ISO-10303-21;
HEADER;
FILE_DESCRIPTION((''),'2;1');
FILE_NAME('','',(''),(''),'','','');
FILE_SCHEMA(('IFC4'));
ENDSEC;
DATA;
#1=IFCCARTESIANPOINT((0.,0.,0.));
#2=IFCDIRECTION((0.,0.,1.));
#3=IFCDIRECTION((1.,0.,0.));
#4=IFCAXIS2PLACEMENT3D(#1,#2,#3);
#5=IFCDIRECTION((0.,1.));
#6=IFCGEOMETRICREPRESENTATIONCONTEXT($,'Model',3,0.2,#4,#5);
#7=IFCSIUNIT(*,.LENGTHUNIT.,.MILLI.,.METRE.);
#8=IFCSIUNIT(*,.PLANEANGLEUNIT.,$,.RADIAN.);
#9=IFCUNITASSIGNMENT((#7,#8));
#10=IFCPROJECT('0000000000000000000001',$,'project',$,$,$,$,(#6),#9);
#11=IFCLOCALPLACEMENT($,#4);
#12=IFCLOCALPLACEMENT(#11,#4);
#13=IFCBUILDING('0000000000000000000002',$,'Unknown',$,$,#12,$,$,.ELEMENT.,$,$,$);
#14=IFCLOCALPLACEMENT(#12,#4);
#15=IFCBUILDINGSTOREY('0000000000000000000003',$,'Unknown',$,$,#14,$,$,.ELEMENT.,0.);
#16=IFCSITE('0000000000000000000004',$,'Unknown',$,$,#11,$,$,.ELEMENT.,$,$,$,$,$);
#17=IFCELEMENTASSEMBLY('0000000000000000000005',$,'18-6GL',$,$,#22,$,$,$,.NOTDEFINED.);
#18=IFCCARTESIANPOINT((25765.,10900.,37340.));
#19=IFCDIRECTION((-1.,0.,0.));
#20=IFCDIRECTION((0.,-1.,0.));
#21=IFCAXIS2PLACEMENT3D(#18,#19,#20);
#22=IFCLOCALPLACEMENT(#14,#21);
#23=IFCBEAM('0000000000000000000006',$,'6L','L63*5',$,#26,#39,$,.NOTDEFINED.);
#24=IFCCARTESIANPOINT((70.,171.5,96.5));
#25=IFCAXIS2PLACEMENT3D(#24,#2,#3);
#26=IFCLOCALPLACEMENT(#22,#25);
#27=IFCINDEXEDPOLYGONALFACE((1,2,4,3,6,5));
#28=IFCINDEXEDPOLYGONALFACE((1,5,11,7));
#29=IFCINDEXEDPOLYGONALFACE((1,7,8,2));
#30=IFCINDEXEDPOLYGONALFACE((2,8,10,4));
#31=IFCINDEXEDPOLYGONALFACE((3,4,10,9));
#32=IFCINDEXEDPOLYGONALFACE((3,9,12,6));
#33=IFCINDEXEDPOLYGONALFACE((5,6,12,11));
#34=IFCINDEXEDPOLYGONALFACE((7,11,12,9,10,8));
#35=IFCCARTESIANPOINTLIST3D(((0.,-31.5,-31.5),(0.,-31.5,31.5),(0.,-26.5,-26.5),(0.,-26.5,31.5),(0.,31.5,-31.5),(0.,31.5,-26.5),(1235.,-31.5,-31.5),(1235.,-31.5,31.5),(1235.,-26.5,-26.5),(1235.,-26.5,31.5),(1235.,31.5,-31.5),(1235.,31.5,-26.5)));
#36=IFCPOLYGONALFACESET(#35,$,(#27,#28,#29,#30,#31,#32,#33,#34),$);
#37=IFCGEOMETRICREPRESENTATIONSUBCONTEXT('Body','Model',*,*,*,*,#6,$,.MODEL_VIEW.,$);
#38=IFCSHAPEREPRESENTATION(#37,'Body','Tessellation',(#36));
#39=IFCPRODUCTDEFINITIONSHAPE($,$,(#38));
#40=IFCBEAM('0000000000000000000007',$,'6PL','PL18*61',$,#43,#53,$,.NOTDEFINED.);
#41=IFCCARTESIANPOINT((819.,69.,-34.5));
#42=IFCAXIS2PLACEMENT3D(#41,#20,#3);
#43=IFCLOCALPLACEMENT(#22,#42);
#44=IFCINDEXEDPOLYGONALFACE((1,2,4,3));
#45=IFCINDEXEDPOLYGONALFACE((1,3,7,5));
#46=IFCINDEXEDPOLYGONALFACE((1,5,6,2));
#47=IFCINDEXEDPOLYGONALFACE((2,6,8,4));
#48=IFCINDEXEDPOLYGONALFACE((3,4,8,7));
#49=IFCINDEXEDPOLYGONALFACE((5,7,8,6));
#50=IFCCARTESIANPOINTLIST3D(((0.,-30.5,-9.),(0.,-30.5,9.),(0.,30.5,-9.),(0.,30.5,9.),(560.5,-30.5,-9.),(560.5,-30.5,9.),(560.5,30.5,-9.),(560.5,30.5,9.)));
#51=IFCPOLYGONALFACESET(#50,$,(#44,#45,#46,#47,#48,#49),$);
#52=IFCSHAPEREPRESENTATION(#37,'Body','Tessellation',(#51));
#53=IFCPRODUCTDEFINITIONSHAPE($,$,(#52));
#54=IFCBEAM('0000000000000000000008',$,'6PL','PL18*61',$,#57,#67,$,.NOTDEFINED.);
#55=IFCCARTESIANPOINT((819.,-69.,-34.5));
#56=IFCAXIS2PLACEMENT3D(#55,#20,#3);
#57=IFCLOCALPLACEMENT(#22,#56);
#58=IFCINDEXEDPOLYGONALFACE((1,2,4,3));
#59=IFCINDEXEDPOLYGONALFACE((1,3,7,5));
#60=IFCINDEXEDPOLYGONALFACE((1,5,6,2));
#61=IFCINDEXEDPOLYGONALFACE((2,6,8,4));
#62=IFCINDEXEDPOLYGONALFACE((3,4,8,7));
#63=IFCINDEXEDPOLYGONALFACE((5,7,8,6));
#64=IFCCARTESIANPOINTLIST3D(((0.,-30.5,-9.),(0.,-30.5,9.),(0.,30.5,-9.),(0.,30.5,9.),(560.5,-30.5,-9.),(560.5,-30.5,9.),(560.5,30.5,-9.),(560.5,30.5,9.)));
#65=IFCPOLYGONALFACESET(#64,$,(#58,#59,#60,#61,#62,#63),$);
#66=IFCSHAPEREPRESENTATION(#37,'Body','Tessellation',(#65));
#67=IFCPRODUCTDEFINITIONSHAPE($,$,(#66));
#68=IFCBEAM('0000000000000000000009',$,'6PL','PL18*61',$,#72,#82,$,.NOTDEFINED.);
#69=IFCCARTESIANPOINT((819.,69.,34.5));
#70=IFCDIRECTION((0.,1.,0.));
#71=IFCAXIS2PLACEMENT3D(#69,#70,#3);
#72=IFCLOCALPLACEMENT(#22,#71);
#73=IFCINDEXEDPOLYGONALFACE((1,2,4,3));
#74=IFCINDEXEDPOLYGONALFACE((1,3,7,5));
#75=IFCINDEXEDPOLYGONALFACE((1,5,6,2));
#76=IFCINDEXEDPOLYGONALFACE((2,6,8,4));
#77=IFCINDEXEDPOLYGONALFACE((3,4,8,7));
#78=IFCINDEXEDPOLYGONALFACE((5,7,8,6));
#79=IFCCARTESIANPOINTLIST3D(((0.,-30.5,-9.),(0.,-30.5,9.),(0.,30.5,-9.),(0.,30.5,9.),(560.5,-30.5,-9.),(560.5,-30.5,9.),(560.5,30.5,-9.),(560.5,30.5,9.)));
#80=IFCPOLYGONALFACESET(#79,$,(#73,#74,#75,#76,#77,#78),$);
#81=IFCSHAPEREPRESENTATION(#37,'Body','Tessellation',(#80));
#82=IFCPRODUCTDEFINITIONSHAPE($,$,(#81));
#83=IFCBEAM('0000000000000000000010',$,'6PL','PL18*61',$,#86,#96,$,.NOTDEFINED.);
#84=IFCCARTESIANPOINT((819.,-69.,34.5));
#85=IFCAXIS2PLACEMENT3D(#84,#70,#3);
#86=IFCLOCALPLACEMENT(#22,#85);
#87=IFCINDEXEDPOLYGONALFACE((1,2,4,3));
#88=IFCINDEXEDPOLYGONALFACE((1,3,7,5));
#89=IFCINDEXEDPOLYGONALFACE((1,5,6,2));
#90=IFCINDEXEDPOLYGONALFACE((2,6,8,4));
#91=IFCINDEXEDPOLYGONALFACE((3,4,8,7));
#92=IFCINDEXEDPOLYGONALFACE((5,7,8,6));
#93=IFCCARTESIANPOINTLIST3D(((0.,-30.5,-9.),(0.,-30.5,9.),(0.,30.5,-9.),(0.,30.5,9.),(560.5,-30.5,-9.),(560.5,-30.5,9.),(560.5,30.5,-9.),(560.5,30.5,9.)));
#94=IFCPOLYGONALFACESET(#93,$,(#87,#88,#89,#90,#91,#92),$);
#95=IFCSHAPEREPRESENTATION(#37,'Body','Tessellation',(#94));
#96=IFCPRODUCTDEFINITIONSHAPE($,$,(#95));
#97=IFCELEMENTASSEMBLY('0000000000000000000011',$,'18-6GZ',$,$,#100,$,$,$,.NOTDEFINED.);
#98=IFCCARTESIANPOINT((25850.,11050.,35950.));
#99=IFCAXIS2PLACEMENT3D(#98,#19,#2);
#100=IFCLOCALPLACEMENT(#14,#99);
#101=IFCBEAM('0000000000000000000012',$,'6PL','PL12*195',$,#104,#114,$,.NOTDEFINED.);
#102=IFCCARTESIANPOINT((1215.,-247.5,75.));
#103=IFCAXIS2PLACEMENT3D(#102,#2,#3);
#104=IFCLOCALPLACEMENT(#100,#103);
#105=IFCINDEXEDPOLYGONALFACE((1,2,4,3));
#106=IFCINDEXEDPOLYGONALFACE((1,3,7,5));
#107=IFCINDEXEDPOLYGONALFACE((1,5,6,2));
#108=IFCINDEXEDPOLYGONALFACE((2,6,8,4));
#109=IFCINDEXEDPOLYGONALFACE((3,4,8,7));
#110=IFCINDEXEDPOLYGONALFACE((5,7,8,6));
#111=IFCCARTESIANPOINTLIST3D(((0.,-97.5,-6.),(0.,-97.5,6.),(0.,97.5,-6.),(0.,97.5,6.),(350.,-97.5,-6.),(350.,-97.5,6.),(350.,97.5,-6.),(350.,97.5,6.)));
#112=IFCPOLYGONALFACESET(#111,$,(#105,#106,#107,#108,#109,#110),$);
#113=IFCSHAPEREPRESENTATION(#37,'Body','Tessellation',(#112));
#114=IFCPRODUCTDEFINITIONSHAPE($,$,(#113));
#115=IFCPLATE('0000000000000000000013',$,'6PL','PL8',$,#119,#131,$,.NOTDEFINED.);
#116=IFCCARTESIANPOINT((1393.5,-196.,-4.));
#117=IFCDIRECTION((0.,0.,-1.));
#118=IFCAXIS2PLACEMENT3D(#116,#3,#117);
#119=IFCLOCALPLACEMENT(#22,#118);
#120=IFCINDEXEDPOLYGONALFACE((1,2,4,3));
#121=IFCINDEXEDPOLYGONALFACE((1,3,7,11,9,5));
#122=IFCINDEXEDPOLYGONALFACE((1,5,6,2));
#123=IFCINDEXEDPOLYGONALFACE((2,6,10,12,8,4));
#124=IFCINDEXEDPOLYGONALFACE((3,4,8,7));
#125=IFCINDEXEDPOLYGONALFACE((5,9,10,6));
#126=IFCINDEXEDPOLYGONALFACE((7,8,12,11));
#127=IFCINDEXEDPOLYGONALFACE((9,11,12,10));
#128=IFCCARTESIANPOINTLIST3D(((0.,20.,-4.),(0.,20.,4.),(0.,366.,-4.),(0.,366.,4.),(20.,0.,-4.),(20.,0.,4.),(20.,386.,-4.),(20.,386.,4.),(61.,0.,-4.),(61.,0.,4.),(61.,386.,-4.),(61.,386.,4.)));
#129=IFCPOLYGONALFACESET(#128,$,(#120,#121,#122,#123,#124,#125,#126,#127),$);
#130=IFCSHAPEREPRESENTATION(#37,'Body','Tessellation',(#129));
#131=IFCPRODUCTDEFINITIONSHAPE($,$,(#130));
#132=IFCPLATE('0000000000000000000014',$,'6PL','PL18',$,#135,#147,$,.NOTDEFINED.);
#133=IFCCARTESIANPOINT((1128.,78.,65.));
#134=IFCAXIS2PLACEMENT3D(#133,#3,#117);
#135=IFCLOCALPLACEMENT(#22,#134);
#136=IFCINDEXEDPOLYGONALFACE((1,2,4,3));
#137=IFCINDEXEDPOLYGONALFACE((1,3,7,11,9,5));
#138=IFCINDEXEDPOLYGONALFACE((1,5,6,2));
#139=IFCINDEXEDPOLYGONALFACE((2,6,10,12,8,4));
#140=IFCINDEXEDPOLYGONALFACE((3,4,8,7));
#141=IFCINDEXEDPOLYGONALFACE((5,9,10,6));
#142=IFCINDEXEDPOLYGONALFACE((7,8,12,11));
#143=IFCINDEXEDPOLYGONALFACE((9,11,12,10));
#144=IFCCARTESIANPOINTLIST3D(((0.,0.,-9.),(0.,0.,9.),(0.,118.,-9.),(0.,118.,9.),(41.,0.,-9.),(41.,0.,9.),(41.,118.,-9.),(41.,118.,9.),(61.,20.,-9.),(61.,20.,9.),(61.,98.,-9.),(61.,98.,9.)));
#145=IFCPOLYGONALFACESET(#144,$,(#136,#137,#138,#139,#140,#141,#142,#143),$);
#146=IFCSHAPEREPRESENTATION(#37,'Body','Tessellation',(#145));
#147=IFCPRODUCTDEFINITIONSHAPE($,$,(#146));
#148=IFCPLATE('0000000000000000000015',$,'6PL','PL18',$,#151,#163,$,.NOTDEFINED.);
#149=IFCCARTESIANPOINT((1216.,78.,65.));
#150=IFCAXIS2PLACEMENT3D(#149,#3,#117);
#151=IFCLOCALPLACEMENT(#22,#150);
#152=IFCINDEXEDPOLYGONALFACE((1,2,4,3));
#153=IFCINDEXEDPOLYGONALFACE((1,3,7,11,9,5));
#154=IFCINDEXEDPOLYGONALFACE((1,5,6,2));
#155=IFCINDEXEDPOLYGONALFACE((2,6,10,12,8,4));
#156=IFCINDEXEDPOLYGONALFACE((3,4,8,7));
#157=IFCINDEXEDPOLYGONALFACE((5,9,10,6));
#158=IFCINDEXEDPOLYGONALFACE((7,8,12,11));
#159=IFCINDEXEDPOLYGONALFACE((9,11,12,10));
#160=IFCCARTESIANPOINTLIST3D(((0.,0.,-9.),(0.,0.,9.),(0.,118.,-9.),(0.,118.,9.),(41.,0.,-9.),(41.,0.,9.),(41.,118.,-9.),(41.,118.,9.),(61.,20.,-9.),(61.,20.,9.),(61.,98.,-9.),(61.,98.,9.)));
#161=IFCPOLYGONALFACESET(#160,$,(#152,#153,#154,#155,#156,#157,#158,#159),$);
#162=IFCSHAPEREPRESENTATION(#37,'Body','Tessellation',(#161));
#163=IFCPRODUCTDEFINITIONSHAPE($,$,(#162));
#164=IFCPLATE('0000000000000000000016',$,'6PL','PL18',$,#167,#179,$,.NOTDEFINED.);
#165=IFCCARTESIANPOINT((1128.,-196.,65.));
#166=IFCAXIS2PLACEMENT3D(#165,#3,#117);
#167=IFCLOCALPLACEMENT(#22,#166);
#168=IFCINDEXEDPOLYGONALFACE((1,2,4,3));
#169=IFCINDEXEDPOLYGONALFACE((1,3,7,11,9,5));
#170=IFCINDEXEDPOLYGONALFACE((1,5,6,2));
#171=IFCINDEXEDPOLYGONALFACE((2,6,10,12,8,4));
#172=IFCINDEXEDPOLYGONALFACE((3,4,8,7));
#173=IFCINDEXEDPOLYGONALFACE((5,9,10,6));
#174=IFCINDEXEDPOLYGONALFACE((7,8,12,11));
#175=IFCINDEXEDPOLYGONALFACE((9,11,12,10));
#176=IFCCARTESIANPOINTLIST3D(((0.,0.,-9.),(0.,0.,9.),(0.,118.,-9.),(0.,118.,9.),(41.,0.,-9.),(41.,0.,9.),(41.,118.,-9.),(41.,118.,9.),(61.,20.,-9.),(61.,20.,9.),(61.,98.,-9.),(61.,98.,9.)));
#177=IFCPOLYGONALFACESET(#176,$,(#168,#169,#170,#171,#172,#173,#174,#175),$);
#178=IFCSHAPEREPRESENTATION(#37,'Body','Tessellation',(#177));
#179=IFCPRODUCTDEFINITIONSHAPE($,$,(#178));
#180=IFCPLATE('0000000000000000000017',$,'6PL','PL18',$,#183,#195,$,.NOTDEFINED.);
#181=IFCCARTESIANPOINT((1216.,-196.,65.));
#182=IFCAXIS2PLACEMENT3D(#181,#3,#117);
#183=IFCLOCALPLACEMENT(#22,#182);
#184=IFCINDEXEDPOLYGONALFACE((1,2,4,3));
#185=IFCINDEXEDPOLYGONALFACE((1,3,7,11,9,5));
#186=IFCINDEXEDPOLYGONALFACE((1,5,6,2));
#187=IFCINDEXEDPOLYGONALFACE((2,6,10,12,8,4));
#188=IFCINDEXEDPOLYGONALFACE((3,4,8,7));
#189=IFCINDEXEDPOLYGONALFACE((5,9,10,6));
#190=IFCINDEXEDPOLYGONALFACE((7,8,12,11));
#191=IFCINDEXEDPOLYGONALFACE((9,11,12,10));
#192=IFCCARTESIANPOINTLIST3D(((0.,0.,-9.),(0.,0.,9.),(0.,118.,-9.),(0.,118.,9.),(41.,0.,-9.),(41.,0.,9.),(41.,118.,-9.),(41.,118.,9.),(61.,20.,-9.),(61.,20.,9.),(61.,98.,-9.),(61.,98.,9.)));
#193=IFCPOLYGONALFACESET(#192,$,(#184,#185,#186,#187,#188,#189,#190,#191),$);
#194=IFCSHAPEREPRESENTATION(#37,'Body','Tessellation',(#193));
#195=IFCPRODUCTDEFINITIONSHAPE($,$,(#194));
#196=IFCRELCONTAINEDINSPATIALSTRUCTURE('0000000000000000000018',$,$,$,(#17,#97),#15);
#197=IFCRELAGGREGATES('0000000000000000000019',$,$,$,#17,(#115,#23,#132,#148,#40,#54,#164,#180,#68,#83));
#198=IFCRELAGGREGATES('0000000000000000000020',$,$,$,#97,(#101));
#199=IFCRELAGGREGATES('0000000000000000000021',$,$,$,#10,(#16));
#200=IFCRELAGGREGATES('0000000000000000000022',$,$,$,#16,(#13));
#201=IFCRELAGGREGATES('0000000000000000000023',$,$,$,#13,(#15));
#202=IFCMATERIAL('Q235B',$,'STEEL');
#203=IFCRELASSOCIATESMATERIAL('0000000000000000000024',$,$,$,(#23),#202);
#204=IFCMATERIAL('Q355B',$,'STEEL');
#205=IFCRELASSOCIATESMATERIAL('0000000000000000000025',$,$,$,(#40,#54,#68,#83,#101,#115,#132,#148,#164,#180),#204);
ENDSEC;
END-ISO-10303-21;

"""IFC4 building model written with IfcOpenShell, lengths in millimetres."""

from ifc_helpers import new_model, si_unit, direction, frame, origin_with_axes, place, context, subcontext, project, spatial, line, indexed_curve, outline, extrude, material, element, aggregate, save


model = new_model("IFC4")

# Units and contexts
model_context = context("Model", 3, precision=0.2, world=origin_with_axes(), true_north=direction((0.0, 1.0)))
body_context = subcontext(model_context, "Body", "Model", "MODEL_VIEW")
ifc_project = project(units=[si_unit("LENGTHUNIT", "METRE", prefix="MILLI"), si_unit("PLANEANGLEUNIT", "RADIAN")], contexts=[model_context])

# Site, building, storey
site_placement = place(None, origin_with_axes())
site = spatial("IfcSite", under=ifc_project, at=site_placement, Name="Unknown", CompositionType="ELEMENT")
building_placement = place(site_placement, origin_with_axes())
building = spatial("IfcBuilding", under=site, at=building_placement, Name="Unknown", CompositionType="ELEMENT")
storey_placement = place(building_placement, origin_with_axes())
storey = spatial("IfcBuildingStorey", under=building, at=storey_placement, Name="Unknown", CompositionType="ELEMENT", Elevation=0.0)

# Element assembly, beams
assembly_1_placement = place(storey_placement, frame((25765.0, 10900.0, 37340.0), z_axis=(-1.0, 0.0, 0.0), x_axis=(0.0, -1.0, 0.0)))
assembly_1 = element("IfcElementAssembly", 1, at=assembly_1_placement, inside=storey, Name="18-6GL", PredefinedType="NOTDEFINED")
ifc_material_1 = material(Name="Q235B", Category="STEEL")
beam_1_placement = place(assembly_1_placement, frame((70.0, 171.5, 96.5), z_axis=(0.0, 0.0, 1.0), x_axis=(1.0, 0.0, 0.0)))
beam_1 = element("IfcBeam", 2, at=beam_1_placement, material=ifc_material_1, Name="6L", Description="L63*5", PredefinedType="NOTDEFINED", context=body_context, shape_type="SolidModel", body=[
    extrude(outline(indexed_curve([(-31.5, -31.5), (31.5, -31.5), (31.5, -26.5), (-26.5, -26.5), (-26.5, 31.5), (-31.5, 31.5)], segments=[line(1, 2, 3, 4, 5, 6, 1)])), frame((0.0, 0.0, 0.0), z_axis=(-1.0, 0.0, 0.0), x_axis=(0.0, 0.0, 1.0)), (0.0, 0.0, -1.0), 1235.0),
])
ifc_material_2 = material(Name="Q355B", Category="STEEL")
beam_2_placement = place(assembly_1_placement, frame((819.0, 69.0, -34.5), z_axis=(0.0, -1.0, 0.0), x_axis=(1.0, 0.0, 0.0)))
beam_2 = element("IfcBeam", 3, at=beam_2_placement, material=ifc_material_2, Name="6PL", Description="PL18*61", PredefinedType="NOTDEFINED", context=body_context, shape_type="SolidModel", body=[
    extrude(outline(indexed_curve([(-9.0, -30.5), (9.0, -30.5), (9.0, 30.5), (-9.0, 30.5)], segments=[line(1, 2, 3, 4, 1)])), frame((0.0, 0.0, 0.0), z_axis=(-1.0, 0.0, 0.0), x_axis=(0.0, 0.0, 1.0)), (0.0, 0.0, -1.0), 560.5),
])
beam_3_placement = place(assembly_1_placement, frame((819.0, -69.0, -34.5), z_axis=(0.0, -1.0, 0.0), x_axis=(1.0, 0.0, 0.0)))
beam_3 = element("IfcBeam", 4, at=beam_3_placement, material=ifc_material_2, Name="6PL", Description="PL18*61", PredefinedType="NOTDEFINED", context=body_context, shape_type="SolidModel", body=[
    extrude(outline(indexed_curve([(-9.0, -30.5), (9.0, -30.5), (9.0, 30.5), (-9.0, 30.5)], segments=[line(1, 2, 3, 4, 1)])), frame((0.0, 0.0, 0.0), z_axis=(-1.0, 0.0, 0.0), x_axis=(0.0, 0.0, 1.0)), (0.0, 0.0, -1.0), 560.5),
])
beam_4_placement = place(assembly_1_placement, frame((819.0, 69.0, 34.5), z_axis=(0.0, 1.0, 0.0), x_axis=(1.0, 0.0, 0.0)))
beam_4 = element("IfcBeam", 5, at=beam_4_placement, material=ifc_material_2, Name="6PL", Description="PL18*61", PredefinedType="NOTDEFINED", context=body_context, shape_type="SolidModel", body=[
    extrude(outline(indexed_curve([(-9.0, -30.5), (9.0, -30.5), (9.0, 30.5), (-9.0, 30.5)], segments=[line(1, 2, 3, 4, 1)])), frame((0.0, 0.0, 0.0), z_axis=(-1.0, 0.0, 0.0), x_axis=(0.0, 0.0, 1.0)), (0.0, 0.0, -1.0), 560.5),
])
beam_5_placement = place(assembly_1_placement, frame((819.0, -69.0, 34.5), z_axis=(0.0, 1.0, 0.0), x_axis=(1.0, 0.0, 0.0)))
beam_5 = element("IfcBeam", 6, at=beam_5_placement, material=ifc_material_2, Name="6PL", Description="PL18*61", PredefinedType="NOTDEFINED", context=body_context, shape_type="SolidModel", body=[
    extrude(outline(indexed_curve([(-9.0, -30.5), (9.0, -30.5), (9.0, 30.5), (-9.0, 30.5)], segments=[line(1, 2, 3, 4, 1)])), frame((0.0, 0.0, 0.0), z_axis=(-1.0, 0.0, 0.0), x_axis=(0.0, 0.0, 1.0)), (0.0, 0.0, -1.0), 560.5),
])

# Element assembly, beam
assembly_2_placement = place(storey_placement, frame((25850.0, 11050.0, 35950.0), z_axis=(-1.0, 0.0, 0.0), x_axis=(0.0, 0.0, 1.0)))
assembly_2 = element("IfcElementAssembly", 7, at=assembly_2_placement, inside=storey, Name="18-6GZ", PredefinedType="NOTDEFINED")
beam_6_placement = place(assembly_2_placement, frame((1215.0, -247.5, 75.0), z_axis=(0.0, 0.0, 1.0), x_axis=(1.0, 0.0, 0.0)))
beam_6 = element("IfcBeam", 8, at=beam_6_placement, material=ifc_material_2, Name="6PL", Description="PL12*195", PredefinedType="NOTDEFINED", context=body_context, shape_type="SolidModel", body=[
    extrude(outline(indexed_curve([(-6.0, -97.5), (6.0, -97.5), (6.0, 97.5), (-6.0, 97.5)], segments=[line(1, 2, 3, 4, 1)])), frame((0.0, 0.0, 0.0), z_axis=(-1.0, 0.0, 0.0), x_axis=(0.0, 0.0, 1.0)), (0.0, 0.0, -1.0), 350.0),
])

# Plates
plate_1_placement = place(assembly_1_placement, frame((1393.5, -196.0, -4.0), z_axis=(1.0, 0.0, 0.0), x_axis=(0.0, 0.0, -1.0)))
plate_1 = element("IfcPlate", 9, at=plate_1_placement, material=ifc_material_2, Name="6PL", Description="PL8", PredefinedType="NOTDEFINED", context=body_context, shape_type="SolidModel", body=[
    extrude(outline(indexed_curve([(0.0, 20.0), (20.0, 0.0), (61.0, 0.0), (61.0, 386.0), (20.0, 386.0), (0.0, 366.0)], segments=[line(1, 2, 3, 4, 5, 6, 1)])), frame((0.0, 0.0, 4.0), z_axis=(0.0, 0.0, 1.0), x_axis=(1.0, 0.0, 0.0)), (0.0, 0.0, -1.0), 8.0),
])
plate_2_placement = place(assembly_1_placement, frame((1128.0, 78.0, 65.0), z_axis=(1.0, 0.0, 0.0), x_axis=(0.0, 0.0, -1.0)))
plate_2 = element("IfcPlate", 10, at=plate_2_placement, material=ifc_material_2, Name="6PL", Description="PL18", PredefinedType="NOTDEFINED", context=body_context, shape_type="SolidModel", body=[
    extrude(outline(indexed_curve([(0.0, 0.0), (41.0, 0.0), (61.0, 20.0), (61.0, 98.0), (41.0, 118.0), (0.0, 118.0)], segments=[line(1, 2, 3, 4, 5, 6, 1)])), frame((0.0, 0.0, 9.0), z_axis=(0.0, 0.0, 1.0), x_axis=(1.0, 0.0, 0.0)), (0.0, 0.0, -1.0), 18.0),
])
plate_3_placement = place(assembly_1_placement, frame((1216.0, 78.0, 65.0), z_axis=(1.0, 0.0, 0.0), x_axis=(0.0, 0.0, -1.0)))
plate_3 = element("IfcPlate", 11, at=plate_3_placement, material=ifc_material_2, Name="6PL", Description="PL18", PredefinedType="NOTDEFINED", context=body_context, shape_type="SolidModel", body=[
    extrude(outline(indexed_curve([(0.0, 0.0), (41.0, 0.0), (61.0, 20.0), (61.0, 98.0), (41.0, 118.0), (0.0, 118.0)], segments=[line(1, 2, 3, 4, 5, 6, 1)])), frame((0.0, 0.0, 9.0), z_axis=(0.0, 0.0, 1.0), x_axis=(1.0, 0.0, 0.0)), (0.0, 0.0, -1.0), 18.0),
])
plate_4_placement = place(assembly_1_placement, frame((1128.0, -196.0, 65.0), z_axis=(1.0, 0.0, 0.0), x_axis=(0.0, 0.0, -1.0)))
plate_4 = element("IfcPlate", 12, at=plate_4_placement, material=ifc_material_2, Name="6PL", Description="PL18", PredefinedType="NOTDEFINED", context=body_context, shape_type="SolidModel", body=[
    extrude(outline(indexed_curve([(0.0, 0.0), (41.0, 0.0), (61.0, 20.0), (61.0, 98.0), (41.0, 118.0), (0.0, 118.0)], segments=[line(1, 2, 3, 4, 5, 6, 1)])), frame((0.0, 0.0, 9.0), z_axis=(0.0, 0.0, 1.0), x_axis=(1.0, 0.0, 0.0)), (0.0, 0.0, -1.0), 18.0),
])
plate_5_placement = place(assembly_1_placement, frame((1216.0, -196.0, 65.0), z_axis=(1.0, 0.0, 0.0), x_axis=(0.0, 0.0, -1.0)))
plate_5 = element("IfcPlate", 13, at=plate_5_placement, material=ifc_material_2, Name="6PL", Description="PL18", PredefinedType="NOTDEFINED", context=body_context, shape_type="SolidModel", body=[
    extrude(outline(indexed_curve([(0.0, 0.0), (41.0, 0.0), (61.0, 20.0), (61.0, 98.0), (41.0, 118.0), (0.0, 118.0)], segments=[line(1, 2, 3, 4, 5, 6, 1)])), frame((0.0, 0.0, 9.0), z_axis=(0.0, 0.0, 1.0), x_axis=(1.0, 0.0, 0.0)), (0.0, 0.0, -1.0), 18.0),
])

aggregate(assembly_1, [plate_1, beam_1, plate_2, plate_3, beam_2, beam_3, plate_4, plate_5, beam_4, beam_5])
aggregate(assembly_2, [beam_6])

save(model, "model.ifc")
